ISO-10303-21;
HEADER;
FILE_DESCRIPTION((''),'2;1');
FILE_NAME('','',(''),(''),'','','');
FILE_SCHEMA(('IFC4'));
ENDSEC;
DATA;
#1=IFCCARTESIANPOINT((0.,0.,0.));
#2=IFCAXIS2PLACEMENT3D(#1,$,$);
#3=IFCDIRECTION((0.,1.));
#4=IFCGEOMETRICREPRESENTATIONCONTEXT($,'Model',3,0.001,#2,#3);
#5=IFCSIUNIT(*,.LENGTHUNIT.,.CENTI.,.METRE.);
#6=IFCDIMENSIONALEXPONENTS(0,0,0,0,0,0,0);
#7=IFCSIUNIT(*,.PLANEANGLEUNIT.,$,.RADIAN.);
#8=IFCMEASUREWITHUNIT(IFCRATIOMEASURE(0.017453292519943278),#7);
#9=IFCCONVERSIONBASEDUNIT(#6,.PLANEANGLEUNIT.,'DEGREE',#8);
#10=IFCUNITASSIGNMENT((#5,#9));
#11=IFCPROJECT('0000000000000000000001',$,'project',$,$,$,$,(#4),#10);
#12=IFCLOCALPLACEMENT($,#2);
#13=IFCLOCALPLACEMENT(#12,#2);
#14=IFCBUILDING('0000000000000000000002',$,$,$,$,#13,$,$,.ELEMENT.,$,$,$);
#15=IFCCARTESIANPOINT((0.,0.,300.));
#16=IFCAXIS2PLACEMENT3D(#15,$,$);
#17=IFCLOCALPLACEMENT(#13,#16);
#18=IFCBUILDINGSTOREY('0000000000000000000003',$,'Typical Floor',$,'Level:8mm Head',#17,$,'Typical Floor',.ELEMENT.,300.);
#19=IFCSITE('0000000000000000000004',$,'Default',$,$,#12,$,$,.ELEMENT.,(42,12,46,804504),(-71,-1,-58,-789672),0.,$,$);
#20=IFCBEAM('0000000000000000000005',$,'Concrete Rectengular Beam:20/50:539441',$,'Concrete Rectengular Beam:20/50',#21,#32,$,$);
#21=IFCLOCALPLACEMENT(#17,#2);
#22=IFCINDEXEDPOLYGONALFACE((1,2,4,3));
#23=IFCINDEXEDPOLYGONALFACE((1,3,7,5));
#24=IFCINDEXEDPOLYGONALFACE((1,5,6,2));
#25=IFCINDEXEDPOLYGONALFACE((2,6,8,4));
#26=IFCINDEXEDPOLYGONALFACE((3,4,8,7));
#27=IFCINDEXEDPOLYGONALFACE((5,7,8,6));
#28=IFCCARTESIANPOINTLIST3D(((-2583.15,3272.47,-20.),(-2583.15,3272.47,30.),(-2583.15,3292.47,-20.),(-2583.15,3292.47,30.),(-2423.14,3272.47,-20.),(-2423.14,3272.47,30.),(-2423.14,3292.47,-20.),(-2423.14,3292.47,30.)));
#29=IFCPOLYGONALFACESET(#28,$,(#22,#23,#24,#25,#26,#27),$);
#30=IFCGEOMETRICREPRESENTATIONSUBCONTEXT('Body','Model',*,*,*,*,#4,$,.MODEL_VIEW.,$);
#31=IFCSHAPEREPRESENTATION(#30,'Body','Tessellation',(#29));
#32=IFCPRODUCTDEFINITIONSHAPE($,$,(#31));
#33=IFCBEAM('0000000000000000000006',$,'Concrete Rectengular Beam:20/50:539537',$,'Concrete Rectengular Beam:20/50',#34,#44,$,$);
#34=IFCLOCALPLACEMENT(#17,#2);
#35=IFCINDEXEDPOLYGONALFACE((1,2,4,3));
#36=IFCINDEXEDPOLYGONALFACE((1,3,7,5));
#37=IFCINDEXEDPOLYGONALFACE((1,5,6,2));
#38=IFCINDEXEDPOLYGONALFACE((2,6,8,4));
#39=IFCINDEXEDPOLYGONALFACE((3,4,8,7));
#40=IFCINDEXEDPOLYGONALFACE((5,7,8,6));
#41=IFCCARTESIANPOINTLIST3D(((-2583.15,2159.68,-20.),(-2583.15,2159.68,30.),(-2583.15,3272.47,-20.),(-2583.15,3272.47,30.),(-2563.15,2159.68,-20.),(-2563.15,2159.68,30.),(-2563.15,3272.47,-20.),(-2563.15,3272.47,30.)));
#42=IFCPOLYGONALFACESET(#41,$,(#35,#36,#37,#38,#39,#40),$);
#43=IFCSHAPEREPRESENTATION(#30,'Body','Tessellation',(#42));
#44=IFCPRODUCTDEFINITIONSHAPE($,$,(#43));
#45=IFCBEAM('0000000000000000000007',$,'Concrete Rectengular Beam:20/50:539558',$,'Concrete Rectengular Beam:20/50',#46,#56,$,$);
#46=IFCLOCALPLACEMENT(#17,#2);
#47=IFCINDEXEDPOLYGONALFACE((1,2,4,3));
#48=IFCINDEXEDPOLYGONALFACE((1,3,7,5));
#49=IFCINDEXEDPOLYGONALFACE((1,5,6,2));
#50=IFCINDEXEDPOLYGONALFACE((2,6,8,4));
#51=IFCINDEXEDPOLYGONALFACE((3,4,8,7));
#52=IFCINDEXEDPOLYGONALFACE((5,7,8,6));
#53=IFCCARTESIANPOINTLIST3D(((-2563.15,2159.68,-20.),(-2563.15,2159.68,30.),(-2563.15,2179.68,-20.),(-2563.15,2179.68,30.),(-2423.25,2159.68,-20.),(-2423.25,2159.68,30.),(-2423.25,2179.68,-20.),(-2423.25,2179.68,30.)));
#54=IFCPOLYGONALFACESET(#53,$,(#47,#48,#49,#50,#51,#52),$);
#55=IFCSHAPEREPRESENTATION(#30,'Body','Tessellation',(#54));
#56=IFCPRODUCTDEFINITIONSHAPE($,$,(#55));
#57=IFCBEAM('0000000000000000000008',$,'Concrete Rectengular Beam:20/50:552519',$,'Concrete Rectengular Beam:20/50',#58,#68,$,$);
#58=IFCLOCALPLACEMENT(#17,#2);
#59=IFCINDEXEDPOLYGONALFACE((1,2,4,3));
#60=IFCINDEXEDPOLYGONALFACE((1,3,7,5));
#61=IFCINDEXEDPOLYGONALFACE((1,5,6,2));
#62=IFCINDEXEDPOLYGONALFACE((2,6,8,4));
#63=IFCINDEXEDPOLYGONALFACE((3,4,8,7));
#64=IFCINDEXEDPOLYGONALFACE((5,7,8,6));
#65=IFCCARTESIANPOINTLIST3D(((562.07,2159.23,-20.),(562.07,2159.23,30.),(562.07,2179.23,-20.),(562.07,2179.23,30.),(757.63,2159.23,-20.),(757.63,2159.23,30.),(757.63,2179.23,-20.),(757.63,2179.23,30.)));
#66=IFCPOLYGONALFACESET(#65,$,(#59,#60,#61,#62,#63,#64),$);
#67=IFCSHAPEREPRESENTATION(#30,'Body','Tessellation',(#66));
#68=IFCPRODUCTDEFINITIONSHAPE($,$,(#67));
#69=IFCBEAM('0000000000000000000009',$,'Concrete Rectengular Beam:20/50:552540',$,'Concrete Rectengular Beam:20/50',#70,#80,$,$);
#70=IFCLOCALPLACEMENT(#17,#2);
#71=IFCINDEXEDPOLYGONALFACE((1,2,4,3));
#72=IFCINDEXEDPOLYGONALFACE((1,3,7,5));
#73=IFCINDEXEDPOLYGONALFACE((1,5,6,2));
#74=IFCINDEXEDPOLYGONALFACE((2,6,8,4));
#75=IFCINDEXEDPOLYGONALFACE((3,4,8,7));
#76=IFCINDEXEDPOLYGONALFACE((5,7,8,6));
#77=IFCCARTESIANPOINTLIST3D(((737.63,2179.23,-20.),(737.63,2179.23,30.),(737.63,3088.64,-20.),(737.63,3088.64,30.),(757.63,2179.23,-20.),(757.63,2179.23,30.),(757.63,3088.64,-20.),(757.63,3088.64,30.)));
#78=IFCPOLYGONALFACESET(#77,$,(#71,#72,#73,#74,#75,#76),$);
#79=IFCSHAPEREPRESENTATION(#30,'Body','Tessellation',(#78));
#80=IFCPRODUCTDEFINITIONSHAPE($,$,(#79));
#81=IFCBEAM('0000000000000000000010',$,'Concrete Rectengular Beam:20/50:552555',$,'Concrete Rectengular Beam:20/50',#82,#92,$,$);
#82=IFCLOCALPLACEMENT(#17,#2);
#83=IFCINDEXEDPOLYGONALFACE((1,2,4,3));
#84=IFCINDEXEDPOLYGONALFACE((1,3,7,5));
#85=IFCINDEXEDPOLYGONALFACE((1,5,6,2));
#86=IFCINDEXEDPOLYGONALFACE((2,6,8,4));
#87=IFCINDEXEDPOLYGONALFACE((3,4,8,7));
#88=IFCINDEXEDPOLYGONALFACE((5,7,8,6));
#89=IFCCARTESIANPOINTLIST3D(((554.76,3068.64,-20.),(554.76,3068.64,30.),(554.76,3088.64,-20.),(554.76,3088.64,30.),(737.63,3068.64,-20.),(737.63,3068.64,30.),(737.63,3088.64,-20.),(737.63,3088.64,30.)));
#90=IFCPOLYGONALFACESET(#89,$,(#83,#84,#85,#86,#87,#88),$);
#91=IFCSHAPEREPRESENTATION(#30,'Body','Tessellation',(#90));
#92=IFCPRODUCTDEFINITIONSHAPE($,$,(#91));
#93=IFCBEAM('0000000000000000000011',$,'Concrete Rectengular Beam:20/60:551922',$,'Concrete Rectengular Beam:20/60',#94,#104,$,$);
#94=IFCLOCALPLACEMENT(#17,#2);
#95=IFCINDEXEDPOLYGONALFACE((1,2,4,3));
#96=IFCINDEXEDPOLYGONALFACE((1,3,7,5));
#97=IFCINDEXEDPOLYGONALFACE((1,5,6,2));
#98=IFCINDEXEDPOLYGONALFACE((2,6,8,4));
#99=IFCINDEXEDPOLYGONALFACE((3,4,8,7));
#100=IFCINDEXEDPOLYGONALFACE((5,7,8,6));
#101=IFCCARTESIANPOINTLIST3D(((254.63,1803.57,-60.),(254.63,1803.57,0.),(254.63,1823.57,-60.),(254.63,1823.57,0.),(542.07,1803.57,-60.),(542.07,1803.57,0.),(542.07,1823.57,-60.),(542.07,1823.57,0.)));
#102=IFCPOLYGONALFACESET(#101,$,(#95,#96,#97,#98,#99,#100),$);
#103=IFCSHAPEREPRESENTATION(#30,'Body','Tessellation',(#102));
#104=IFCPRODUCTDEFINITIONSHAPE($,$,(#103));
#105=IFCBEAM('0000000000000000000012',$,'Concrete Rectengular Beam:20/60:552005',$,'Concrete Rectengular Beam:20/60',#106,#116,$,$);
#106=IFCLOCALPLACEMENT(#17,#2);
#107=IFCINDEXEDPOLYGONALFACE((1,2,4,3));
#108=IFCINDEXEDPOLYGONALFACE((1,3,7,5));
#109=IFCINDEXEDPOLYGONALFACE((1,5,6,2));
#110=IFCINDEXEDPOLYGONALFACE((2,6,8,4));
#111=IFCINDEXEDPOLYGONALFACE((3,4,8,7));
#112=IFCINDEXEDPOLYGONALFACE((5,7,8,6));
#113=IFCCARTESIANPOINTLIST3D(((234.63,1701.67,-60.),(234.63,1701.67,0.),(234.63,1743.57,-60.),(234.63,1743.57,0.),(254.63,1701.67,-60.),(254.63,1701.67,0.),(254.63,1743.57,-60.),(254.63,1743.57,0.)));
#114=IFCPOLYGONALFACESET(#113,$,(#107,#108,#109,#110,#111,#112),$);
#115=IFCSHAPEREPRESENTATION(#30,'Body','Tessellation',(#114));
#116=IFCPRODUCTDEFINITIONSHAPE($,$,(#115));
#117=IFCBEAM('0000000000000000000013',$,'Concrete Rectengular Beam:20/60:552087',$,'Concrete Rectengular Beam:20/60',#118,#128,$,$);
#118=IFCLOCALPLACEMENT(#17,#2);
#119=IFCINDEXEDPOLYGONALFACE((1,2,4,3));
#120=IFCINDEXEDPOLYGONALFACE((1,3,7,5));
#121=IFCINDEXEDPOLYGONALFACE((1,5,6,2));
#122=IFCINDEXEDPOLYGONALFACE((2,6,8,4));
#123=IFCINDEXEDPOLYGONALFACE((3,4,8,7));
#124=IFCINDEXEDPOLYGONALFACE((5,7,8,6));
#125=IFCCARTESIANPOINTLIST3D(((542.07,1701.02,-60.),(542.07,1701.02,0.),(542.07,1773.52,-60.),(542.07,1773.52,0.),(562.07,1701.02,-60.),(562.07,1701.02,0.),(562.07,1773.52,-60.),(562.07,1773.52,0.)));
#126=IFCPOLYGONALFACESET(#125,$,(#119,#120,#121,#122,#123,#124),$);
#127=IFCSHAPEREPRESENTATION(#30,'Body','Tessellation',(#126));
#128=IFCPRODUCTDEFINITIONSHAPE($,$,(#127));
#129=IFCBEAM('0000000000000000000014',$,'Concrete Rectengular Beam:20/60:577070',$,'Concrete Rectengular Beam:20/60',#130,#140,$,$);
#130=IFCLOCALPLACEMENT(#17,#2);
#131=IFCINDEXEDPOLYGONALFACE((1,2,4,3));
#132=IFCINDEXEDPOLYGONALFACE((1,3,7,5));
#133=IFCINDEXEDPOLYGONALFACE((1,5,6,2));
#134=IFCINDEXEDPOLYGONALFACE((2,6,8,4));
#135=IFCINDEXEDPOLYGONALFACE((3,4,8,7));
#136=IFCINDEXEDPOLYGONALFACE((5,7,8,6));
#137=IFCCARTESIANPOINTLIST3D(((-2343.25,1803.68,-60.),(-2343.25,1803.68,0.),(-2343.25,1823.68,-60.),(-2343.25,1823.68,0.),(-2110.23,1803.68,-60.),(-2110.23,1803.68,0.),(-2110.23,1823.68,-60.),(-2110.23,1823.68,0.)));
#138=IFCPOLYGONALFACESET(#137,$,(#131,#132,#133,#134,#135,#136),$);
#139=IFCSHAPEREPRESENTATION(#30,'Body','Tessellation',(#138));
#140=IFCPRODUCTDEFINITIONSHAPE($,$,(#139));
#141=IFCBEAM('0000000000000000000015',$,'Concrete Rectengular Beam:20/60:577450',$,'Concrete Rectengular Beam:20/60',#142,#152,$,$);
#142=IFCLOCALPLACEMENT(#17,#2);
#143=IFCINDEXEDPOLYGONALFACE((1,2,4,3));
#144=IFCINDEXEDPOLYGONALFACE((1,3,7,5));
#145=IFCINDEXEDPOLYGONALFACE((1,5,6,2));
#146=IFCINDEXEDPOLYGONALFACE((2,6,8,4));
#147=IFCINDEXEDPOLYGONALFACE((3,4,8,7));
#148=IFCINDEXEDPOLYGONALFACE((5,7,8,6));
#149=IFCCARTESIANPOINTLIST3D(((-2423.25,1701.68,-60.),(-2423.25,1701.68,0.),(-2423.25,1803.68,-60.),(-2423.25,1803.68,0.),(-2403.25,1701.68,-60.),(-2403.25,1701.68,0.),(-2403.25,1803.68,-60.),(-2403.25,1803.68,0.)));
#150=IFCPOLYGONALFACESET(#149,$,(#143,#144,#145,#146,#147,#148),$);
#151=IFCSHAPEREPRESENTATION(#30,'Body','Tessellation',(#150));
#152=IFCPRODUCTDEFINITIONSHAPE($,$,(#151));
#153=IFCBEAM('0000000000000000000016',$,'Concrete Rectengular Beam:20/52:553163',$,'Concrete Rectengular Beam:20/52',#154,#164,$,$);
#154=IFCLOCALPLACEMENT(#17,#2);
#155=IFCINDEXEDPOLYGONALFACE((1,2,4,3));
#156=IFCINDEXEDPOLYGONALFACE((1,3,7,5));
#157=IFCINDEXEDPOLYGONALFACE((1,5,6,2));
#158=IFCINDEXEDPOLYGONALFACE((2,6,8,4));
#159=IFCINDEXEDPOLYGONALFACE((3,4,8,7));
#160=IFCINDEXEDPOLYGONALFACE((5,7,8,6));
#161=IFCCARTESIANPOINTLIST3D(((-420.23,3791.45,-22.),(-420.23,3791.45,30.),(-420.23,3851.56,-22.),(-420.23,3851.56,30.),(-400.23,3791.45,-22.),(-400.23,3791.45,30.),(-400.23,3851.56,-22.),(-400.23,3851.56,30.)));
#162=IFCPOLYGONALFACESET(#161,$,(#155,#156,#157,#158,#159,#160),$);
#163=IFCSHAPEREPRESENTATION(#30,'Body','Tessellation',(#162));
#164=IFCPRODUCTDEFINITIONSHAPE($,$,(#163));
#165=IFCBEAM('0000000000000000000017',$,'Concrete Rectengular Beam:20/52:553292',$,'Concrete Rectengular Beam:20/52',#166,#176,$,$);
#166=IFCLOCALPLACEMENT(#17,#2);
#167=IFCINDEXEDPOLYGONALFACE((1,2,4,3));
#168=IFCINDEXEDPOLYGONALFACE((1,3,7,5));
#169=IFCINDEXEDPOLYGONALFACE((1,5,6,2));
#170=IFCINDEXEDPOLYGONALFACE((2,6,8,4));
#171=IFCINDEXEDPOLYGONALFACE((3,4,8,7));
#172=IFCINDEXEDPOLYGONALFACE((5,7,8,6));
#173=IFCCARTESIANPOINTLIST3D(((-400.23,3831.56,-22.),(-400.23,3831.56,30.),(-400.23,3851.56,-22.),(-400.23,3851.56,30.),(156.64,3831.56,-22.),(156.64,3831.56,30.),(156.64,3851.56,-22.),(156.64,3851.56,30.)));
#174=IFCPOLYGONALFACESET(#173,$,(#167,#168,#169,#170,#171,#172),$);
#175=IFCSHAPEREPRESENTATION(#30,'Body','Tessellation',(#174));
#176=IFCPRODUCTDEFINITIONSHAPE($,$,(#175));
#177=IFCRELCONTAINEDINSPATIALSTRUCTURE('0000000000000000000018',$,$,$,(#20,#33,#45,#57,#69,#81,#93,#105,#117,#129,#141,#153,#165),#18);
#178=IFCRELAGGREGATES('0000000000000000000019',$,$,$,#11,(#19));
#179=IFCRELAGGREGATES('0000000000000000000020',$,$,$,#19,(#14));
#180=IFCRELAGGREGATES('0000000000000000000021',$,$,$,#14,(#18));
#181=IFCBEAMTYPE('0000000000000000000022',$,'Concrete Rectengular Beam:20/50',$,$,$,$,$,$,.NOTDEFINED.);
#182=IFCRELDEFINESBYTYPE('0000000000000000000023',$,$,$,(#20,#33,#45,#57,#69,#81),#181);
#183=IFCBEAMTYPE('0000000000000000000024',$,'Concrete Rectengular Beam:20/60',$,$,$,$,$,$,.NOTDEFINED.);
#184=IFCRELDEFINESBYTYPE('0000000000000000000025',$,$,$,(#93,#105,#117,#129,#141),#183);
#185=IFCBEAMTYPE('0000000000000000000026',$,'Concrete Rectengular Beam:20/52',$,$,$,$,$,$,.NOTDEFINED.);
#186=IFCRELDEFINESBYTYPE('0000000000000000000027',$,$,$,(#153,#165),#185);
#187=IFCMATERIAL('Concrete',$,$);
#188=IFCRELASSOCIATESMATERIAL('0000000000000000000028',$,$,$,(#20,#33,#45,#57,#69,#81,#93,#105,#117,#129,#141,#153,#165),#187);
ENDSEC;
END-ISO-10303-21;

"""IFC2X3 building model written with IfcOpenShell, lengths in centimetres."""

from ifc_helpers import new_model, entity, si_unit, converted_unit, direction, frame, frame_2d, origin, origin_2d_with_axis, place, context, subcontext, project, spatial, rectangle, extrude, material, type_object, element, save


model = new_model("IFC2X3")

# Units and contexts
model_context = context("Model", 3, precision=0.001, world=origin(), true_north=direction((0.0, 1.0)))
body_context = subcontext(model_context, "Body", "Model", "MODEL_VIEW")
ifc_project = project(units=[si_unit("LENGTHUNIT", "METRE", prefix="CENTI"), converted_unit("PLANEANGLEUNIT", "DEGREE", entity("IfcRatioMeasure", 0.017453292519943278), si_unit("PLANEANGLEUNIT", "RADIAN"), dimensions=[0, 0, 0, 0, 0, 0, 0])], contexts=[model_context])

# Site, building, storey
site_placement = place(None, origin())
site = spatial("IfcSite", under=ifc_project, at=site_placement, Name="Default", CompositionType="ELEMENT", RefLatitude=(42, 12, 46, 804504), RefLongitude=(-71, -1, -58, -789672), RefElevation=0.0)
building_placement = place(site_placement, origin())
building = spatial("IfcBuilding", under=site, at=building_placement, CompositionType="ELEMENT")
storey_placement = place(building_placement, frame((0.0, 0.0, 300.0)))
storey = spatial("IfcBuildingStorey", under=building, at=storey_placement, Name="Typical Floor", ObjectType="Level:8mm Head", LongName="Typical Floor", CompositionType="ELEMENT", Elevation=300.0)

# Beams
ifc_material = material(Name="Concrete")
beam_type_1 = type_object("IfcBeamType", Name="Concrete Rectengular Beam:20/50", PredefinedType="NOTDEFINED")
beam_1_placement = place(storey_placement, frame((-2423.14, 3272.47, 0.0), z_axis=(0.0, 0.0, 1.0), x_axis=(-1.0, 0.0, 0.0)))
element("IfcBeam", 1, at=beam_1_placement, inside=storey, type_object=beam_type_1, material=ifc_material, Name="Concrete Rectengular Beam:20/50:539441", ObjectType="Concrete Rectengular Beam:20/50", context=body_context, shape_type="SweptSolid", body=[
    extrude(rectangle(XDim=50.0, YDim=20.0, at=frame_2d((0.0, 0.0), x_axis=(1.0, 0.0))), frame((0.0, -10.0, 5.0), z_axis=(1.0, 0.0, 0.0), x_axis=(0.0, 0.0, -1.0)), (0.0, 0.0, 1.0), 160.01),
])
beam_2_placement = place(storey_placement, frame((-2563.15, 3272.47, 0.0), z_axis=(0.0, 0.0, 1.0), x_axis=(0.0, -1.0, 0.0)))
element("IfcBeam", 2, at=beam_2_placement, inside=storey, type_object=beam_type_1, material=ifc_material, Name="Concrete Rectengular Beam:20/50:539537", ObjectType="Concrete Rectengular Beam:20/50", context=body_context, shape_type="SweptSolid", body=[
    extrude(rectangle(XDim=50.0, YDim=20.0, at=frame_2d((0.0, 0.0), x_axis=(1.0, 0.0))), frame((0.0, -10.0, 5.0), z_axis=(1.0, 0.0, 0.0), x_axis=(0.0, 0.0, -1.0)), (0.0, 0.0, 1.0), 1112.78),
])
beam_3_placement = place(storey_placement, frame((-2563.15, 2179.68, 0.0)))
element("IfcBeam", 3, at=beam_3_placement, inside=storey, type_object=beam_type_1, material=ifc_material, Name="Concrete Rectengular Beam:20/50:539558", ObjectType="Concrete Rectengular Beam:20/50", context=body_context, shape_type="SweptSolid", body=[
    extrude(rectangle(XDim=50.0, YDim=20.0, at=frame_2d((0.0, 0.0), x_axis=(1.0, 0.0))), frame((0.0, -10.0, 5.0), z_axis=(1.0, 0.0, 0.0), x_axis=(0.0, 0.0, -1.0)), (0.0, 0.0, 1.0), 139.91),
])
beam_4_placement = place(storey_placement, frame((562.07, 2179.23, 0.0)))
element("IfcBeam", 4, at=beam_4_placement, inside=storey, type_object=beam_type_1, material=ifc_material, Name="Concrete Rectengular Beam:20/50:552519", ObjectType="Concrete Rectengular Beam:20/50", context=body_context, shape_type="SweptSolid", body=[
    extrude(rectangle(XDim=50.0, YDim=20.0, at=frame_2d((0.0, 0.0), x_axis=(1.0, 0.0))), frame((0.0, -10.0, 5.0), z_axis=(1.0, 0.0, 0.0), x_axis=(0.0, 0.0, -1.0)), (0.0, 0.0, 1.0), 195.55),
])
beam_5_placement = place(storey_placement, frame((737.63, 2179.23, 0.0), z_axis=(0.0, 0.0, 1.0), x_axis=(0.0, 1.0, 0.0)))
element("IfcBeam", 5, at=beam_5_placement, inside=storey, type_object=beam_type_1, material=ifc_material, Name="Concrete Rectengular Beam:20/50:552540", ObjectType="Concrete Rectengular Beam:20/50", context=body_context, shape_type="SweptSolid", body=[
    extrude(rectangle(XDim=50.0, YDim=20.0, at=frame_2d((0.0, 0.0), x_axis=(1.0, 0.0))), frame((0.0, -10.0, 5.0), z_axis=(1.0, 0.0, 0.0), x_axis=(0.0, 0.0, -1.0)), (0.0, 0.0, 1.0), 909.41),
])
beam_6_placement = place(storey_placement, frame((737.63, 3068.64, 0.0), z_axis=(0.0, 0.0, 1.0), x_axis=(-1.0, 0.0, 0.0)))
element("IfcBeam", 6, at=beam_6_placement, inside=storey, type_object=beam_type_1, material=ifc_material, Name="Concrete Rectengular Beam:20/50:552555", ObjectType="Concrete Rectengular Beam:20/50", context=body_context, shape_type="SweptSolid", body=[
    extrude(rectangle(XDim=50.0, YDim=20.0, at=frame_2d((0.0, 0.0), x_axis=(1.0, 0.0))), frame((0.0, -10.0, 5.0), z_axis=(1.0, 0.0, 0.0), x_axis=(0.0, 0.0, -1.0)), (0.0, 0.0, 1.0), 182.87),
])
beam_type_2 = type_object("IfcBeamType", Name="Concrete Rectengular Beam:20/60", PredefinedType="NOTDEFINED")
beam_7_placement = place(storey_placement, frame((551.63, 1803.57, 0.0), z_axis=(0.0, 0.0, 1.0), x_axis=(-1.0, 0.0, 0.0)))
element("IfcBeam", 7, at=beam_7_placement, inside=storey, type_object=beam_type_2, material=ifc_material, Name="Concrete Rectengular Beam:20/60:551922", ObjectType="Concrete Rectengular Beam:20/60", context=body_context, shape_type="SweptSolid", body=[
    extrude(rectangle(XDim=60.0, YDim=20.0, at=frame_2d((0.0, 0.0), x_axis=(1.0, 0.0))), frame((9.56, -10.0, -30.0), z_axis=(1.0, 0.0, 0.0), x_axis=(0.0, 0.0, -1.0)), (0.0, 0.0, 1.0), 287.44),
])
beam_8_placement = place(storey_placement, frame((254.63, 1783.67, 0.0), z_axis=(0.0, 0.0, 1.0), x_axis=(0.0, -1.0, 0.0)))
element("IfcBeam", 8, at=beam_8_placement, inside=storey, type_object=beam_type_2, material=ifc_material, Name="Concrete Rectengular Beam:20/60:552005", ObjectType="Concrete Rectengular Beam:20/60", context=body_context, shape_type="SweptSolid", body=[
    extrude(rectangle(XDim=60.0, YDim=20.0, at=origin_2d_with_axis()), frame((40.1, -10.0, -30.0), z_axis=(1.0, 0.0, 0.0), x_axis=(0.0, 0.0, -1.0)), (0.0, 0.0, 1.0), 41.9),
])
beam_9_placement = place(storey_placement, frame((562.07, 1813.52, 0.0), z_axis=(0.0, 0.0, 1.0), x_axis=(0.0, -1.0, 0.0)))
element("IfcBeam", 9, at=beam_9_placement, inside=storey, type_object=beam_type_2, material=ifc_material, Name="Concrete Rectengular Beam:20/60:552087", ObjectType="Concrete Rectengular Beam:20/60", context=body_context, shape_type="SweptSolid", body=[
    extrude(rectangle(XDim=60.0, YDim=20.0, at=frame_2d((0.0, 0.0), x_axis=(1.0, 0.0))), frame((40.0, -10.0, -30.0), z_axis=(1.0, 0.0, 0.0), x_axis=(0.0, 0.0, -1.0)), (0.0, 0.0, 1.0), 72.5),
])
beam_10_placement = place(storey_placement, frame((-2383.25, 1823.68, 0.0)))
element("IfcBeam", 10, at=beam_10_placement, inside=storey, type_object=beam_type_2, material=ifc_material, Name="Concrete Rectengular Beam:20/60:577070", ObjectType="Concrete Rectengular Beam:20/60", context=body_context, shape_type="SweptSolid", body=[
    extrude(rectangle(XDim=60.0, YDim=20.0, at=frame_2d((0.0, 0.0), x_axis=(1.0, 0.0))), frame((40.0, -10.0, -30.0), z_axis=(1.0, 0.0, 0.0), x_axis=(0.0, 0.0, -1.0)), (0.0, 0.0, 1.0), 233.02),
])
beam_11_placement = place(storey_placement, frame((-2403.25, 1813.68, 0.0), z_axis=(0.0, 0.0, 1.0), x_axis=(0.0, -1.0, 0.0)))
element("IfcBeam", 11, at=beam_11_placement, inside=storey, type_object=beam_type_2, material=ifc_material, Name="Concrete Rectengular Beam:20/60:577450", ObjectType="Concrete Rectengular Beam:20/60", context=body_context, shape_type="SweptSolid", body=[
    extrude(rectangle(XDim=60.0, YDim=20.0, at=frame_2d((0.0, 0.0), x_axis=(1.0, 0.0))), frame((10.0, -10.0, -30.0), z_axis=(1.0, 0.0, 0.0), x_axis=(0.0, 0.0, -1.0)), (0.0, 0.0, 1.0), 102.0),
])
beam_type_3 = type_object("IfcBeamType", Name="Concrete Rectengular Beam:20/52", PredefinedType="NOTDEFINED")
beam_12_placement = place(storey_placement, frame((-400.23, 3871.45, 0.0), z_axis=(0.0, 0.0, 1.0), x_axis=(0.0, -1.0, 0.0)))
element("IfcBeam", 12, at=beam_12_placement, inside=storey, type_object=beam_type_3, material=ifc_material, Name="Concrete Rectengular Beam:20/52:553163", ObjectType="Concrete Rectengular Beam:20/52", context=body_context, shape_type="SweptSolid", body=[
    extrude(rectangle(XDim=52.0, YDim=20.0, at=frame_2d((0.0, 0.0), x_axis=(1.0, 0.0))), frame((19.9, -10.0, 4.0), z_axis=(1.0, 0.0, 0.0), x_axis=(0.0, 0.0, -1.0)), (0.0, 0.0, 1.0), 60.11),
])
beam_13_placement = place(storey_placement, frame((-400.23, 3851.56, 0.0)))
element("IfcBeam", 13, at=beam_13_placement, inside=storey, type_object=beam_type_3, material=ifc_material, Name="Concrete Rectengular Beam:20/52:553292", ObjectType="Concrete Rectengular Beam:20/52", context=body_context, shape_type="SweptSolid", body=[
    extrude(rectangle(XDim=52.0, YDim=20.0, at=frame_2d((0.0, 0.0), x_axis=(1.0, 0.0))), frame((0.0, -10.0, 4.0), z_axis=(1.0, 0.0, 0.0), x_axis=(0.0, 0.0, -1.0)), (0.0, 0.0, 1.0), 556.87),
])

save(model, "model.ifc")
